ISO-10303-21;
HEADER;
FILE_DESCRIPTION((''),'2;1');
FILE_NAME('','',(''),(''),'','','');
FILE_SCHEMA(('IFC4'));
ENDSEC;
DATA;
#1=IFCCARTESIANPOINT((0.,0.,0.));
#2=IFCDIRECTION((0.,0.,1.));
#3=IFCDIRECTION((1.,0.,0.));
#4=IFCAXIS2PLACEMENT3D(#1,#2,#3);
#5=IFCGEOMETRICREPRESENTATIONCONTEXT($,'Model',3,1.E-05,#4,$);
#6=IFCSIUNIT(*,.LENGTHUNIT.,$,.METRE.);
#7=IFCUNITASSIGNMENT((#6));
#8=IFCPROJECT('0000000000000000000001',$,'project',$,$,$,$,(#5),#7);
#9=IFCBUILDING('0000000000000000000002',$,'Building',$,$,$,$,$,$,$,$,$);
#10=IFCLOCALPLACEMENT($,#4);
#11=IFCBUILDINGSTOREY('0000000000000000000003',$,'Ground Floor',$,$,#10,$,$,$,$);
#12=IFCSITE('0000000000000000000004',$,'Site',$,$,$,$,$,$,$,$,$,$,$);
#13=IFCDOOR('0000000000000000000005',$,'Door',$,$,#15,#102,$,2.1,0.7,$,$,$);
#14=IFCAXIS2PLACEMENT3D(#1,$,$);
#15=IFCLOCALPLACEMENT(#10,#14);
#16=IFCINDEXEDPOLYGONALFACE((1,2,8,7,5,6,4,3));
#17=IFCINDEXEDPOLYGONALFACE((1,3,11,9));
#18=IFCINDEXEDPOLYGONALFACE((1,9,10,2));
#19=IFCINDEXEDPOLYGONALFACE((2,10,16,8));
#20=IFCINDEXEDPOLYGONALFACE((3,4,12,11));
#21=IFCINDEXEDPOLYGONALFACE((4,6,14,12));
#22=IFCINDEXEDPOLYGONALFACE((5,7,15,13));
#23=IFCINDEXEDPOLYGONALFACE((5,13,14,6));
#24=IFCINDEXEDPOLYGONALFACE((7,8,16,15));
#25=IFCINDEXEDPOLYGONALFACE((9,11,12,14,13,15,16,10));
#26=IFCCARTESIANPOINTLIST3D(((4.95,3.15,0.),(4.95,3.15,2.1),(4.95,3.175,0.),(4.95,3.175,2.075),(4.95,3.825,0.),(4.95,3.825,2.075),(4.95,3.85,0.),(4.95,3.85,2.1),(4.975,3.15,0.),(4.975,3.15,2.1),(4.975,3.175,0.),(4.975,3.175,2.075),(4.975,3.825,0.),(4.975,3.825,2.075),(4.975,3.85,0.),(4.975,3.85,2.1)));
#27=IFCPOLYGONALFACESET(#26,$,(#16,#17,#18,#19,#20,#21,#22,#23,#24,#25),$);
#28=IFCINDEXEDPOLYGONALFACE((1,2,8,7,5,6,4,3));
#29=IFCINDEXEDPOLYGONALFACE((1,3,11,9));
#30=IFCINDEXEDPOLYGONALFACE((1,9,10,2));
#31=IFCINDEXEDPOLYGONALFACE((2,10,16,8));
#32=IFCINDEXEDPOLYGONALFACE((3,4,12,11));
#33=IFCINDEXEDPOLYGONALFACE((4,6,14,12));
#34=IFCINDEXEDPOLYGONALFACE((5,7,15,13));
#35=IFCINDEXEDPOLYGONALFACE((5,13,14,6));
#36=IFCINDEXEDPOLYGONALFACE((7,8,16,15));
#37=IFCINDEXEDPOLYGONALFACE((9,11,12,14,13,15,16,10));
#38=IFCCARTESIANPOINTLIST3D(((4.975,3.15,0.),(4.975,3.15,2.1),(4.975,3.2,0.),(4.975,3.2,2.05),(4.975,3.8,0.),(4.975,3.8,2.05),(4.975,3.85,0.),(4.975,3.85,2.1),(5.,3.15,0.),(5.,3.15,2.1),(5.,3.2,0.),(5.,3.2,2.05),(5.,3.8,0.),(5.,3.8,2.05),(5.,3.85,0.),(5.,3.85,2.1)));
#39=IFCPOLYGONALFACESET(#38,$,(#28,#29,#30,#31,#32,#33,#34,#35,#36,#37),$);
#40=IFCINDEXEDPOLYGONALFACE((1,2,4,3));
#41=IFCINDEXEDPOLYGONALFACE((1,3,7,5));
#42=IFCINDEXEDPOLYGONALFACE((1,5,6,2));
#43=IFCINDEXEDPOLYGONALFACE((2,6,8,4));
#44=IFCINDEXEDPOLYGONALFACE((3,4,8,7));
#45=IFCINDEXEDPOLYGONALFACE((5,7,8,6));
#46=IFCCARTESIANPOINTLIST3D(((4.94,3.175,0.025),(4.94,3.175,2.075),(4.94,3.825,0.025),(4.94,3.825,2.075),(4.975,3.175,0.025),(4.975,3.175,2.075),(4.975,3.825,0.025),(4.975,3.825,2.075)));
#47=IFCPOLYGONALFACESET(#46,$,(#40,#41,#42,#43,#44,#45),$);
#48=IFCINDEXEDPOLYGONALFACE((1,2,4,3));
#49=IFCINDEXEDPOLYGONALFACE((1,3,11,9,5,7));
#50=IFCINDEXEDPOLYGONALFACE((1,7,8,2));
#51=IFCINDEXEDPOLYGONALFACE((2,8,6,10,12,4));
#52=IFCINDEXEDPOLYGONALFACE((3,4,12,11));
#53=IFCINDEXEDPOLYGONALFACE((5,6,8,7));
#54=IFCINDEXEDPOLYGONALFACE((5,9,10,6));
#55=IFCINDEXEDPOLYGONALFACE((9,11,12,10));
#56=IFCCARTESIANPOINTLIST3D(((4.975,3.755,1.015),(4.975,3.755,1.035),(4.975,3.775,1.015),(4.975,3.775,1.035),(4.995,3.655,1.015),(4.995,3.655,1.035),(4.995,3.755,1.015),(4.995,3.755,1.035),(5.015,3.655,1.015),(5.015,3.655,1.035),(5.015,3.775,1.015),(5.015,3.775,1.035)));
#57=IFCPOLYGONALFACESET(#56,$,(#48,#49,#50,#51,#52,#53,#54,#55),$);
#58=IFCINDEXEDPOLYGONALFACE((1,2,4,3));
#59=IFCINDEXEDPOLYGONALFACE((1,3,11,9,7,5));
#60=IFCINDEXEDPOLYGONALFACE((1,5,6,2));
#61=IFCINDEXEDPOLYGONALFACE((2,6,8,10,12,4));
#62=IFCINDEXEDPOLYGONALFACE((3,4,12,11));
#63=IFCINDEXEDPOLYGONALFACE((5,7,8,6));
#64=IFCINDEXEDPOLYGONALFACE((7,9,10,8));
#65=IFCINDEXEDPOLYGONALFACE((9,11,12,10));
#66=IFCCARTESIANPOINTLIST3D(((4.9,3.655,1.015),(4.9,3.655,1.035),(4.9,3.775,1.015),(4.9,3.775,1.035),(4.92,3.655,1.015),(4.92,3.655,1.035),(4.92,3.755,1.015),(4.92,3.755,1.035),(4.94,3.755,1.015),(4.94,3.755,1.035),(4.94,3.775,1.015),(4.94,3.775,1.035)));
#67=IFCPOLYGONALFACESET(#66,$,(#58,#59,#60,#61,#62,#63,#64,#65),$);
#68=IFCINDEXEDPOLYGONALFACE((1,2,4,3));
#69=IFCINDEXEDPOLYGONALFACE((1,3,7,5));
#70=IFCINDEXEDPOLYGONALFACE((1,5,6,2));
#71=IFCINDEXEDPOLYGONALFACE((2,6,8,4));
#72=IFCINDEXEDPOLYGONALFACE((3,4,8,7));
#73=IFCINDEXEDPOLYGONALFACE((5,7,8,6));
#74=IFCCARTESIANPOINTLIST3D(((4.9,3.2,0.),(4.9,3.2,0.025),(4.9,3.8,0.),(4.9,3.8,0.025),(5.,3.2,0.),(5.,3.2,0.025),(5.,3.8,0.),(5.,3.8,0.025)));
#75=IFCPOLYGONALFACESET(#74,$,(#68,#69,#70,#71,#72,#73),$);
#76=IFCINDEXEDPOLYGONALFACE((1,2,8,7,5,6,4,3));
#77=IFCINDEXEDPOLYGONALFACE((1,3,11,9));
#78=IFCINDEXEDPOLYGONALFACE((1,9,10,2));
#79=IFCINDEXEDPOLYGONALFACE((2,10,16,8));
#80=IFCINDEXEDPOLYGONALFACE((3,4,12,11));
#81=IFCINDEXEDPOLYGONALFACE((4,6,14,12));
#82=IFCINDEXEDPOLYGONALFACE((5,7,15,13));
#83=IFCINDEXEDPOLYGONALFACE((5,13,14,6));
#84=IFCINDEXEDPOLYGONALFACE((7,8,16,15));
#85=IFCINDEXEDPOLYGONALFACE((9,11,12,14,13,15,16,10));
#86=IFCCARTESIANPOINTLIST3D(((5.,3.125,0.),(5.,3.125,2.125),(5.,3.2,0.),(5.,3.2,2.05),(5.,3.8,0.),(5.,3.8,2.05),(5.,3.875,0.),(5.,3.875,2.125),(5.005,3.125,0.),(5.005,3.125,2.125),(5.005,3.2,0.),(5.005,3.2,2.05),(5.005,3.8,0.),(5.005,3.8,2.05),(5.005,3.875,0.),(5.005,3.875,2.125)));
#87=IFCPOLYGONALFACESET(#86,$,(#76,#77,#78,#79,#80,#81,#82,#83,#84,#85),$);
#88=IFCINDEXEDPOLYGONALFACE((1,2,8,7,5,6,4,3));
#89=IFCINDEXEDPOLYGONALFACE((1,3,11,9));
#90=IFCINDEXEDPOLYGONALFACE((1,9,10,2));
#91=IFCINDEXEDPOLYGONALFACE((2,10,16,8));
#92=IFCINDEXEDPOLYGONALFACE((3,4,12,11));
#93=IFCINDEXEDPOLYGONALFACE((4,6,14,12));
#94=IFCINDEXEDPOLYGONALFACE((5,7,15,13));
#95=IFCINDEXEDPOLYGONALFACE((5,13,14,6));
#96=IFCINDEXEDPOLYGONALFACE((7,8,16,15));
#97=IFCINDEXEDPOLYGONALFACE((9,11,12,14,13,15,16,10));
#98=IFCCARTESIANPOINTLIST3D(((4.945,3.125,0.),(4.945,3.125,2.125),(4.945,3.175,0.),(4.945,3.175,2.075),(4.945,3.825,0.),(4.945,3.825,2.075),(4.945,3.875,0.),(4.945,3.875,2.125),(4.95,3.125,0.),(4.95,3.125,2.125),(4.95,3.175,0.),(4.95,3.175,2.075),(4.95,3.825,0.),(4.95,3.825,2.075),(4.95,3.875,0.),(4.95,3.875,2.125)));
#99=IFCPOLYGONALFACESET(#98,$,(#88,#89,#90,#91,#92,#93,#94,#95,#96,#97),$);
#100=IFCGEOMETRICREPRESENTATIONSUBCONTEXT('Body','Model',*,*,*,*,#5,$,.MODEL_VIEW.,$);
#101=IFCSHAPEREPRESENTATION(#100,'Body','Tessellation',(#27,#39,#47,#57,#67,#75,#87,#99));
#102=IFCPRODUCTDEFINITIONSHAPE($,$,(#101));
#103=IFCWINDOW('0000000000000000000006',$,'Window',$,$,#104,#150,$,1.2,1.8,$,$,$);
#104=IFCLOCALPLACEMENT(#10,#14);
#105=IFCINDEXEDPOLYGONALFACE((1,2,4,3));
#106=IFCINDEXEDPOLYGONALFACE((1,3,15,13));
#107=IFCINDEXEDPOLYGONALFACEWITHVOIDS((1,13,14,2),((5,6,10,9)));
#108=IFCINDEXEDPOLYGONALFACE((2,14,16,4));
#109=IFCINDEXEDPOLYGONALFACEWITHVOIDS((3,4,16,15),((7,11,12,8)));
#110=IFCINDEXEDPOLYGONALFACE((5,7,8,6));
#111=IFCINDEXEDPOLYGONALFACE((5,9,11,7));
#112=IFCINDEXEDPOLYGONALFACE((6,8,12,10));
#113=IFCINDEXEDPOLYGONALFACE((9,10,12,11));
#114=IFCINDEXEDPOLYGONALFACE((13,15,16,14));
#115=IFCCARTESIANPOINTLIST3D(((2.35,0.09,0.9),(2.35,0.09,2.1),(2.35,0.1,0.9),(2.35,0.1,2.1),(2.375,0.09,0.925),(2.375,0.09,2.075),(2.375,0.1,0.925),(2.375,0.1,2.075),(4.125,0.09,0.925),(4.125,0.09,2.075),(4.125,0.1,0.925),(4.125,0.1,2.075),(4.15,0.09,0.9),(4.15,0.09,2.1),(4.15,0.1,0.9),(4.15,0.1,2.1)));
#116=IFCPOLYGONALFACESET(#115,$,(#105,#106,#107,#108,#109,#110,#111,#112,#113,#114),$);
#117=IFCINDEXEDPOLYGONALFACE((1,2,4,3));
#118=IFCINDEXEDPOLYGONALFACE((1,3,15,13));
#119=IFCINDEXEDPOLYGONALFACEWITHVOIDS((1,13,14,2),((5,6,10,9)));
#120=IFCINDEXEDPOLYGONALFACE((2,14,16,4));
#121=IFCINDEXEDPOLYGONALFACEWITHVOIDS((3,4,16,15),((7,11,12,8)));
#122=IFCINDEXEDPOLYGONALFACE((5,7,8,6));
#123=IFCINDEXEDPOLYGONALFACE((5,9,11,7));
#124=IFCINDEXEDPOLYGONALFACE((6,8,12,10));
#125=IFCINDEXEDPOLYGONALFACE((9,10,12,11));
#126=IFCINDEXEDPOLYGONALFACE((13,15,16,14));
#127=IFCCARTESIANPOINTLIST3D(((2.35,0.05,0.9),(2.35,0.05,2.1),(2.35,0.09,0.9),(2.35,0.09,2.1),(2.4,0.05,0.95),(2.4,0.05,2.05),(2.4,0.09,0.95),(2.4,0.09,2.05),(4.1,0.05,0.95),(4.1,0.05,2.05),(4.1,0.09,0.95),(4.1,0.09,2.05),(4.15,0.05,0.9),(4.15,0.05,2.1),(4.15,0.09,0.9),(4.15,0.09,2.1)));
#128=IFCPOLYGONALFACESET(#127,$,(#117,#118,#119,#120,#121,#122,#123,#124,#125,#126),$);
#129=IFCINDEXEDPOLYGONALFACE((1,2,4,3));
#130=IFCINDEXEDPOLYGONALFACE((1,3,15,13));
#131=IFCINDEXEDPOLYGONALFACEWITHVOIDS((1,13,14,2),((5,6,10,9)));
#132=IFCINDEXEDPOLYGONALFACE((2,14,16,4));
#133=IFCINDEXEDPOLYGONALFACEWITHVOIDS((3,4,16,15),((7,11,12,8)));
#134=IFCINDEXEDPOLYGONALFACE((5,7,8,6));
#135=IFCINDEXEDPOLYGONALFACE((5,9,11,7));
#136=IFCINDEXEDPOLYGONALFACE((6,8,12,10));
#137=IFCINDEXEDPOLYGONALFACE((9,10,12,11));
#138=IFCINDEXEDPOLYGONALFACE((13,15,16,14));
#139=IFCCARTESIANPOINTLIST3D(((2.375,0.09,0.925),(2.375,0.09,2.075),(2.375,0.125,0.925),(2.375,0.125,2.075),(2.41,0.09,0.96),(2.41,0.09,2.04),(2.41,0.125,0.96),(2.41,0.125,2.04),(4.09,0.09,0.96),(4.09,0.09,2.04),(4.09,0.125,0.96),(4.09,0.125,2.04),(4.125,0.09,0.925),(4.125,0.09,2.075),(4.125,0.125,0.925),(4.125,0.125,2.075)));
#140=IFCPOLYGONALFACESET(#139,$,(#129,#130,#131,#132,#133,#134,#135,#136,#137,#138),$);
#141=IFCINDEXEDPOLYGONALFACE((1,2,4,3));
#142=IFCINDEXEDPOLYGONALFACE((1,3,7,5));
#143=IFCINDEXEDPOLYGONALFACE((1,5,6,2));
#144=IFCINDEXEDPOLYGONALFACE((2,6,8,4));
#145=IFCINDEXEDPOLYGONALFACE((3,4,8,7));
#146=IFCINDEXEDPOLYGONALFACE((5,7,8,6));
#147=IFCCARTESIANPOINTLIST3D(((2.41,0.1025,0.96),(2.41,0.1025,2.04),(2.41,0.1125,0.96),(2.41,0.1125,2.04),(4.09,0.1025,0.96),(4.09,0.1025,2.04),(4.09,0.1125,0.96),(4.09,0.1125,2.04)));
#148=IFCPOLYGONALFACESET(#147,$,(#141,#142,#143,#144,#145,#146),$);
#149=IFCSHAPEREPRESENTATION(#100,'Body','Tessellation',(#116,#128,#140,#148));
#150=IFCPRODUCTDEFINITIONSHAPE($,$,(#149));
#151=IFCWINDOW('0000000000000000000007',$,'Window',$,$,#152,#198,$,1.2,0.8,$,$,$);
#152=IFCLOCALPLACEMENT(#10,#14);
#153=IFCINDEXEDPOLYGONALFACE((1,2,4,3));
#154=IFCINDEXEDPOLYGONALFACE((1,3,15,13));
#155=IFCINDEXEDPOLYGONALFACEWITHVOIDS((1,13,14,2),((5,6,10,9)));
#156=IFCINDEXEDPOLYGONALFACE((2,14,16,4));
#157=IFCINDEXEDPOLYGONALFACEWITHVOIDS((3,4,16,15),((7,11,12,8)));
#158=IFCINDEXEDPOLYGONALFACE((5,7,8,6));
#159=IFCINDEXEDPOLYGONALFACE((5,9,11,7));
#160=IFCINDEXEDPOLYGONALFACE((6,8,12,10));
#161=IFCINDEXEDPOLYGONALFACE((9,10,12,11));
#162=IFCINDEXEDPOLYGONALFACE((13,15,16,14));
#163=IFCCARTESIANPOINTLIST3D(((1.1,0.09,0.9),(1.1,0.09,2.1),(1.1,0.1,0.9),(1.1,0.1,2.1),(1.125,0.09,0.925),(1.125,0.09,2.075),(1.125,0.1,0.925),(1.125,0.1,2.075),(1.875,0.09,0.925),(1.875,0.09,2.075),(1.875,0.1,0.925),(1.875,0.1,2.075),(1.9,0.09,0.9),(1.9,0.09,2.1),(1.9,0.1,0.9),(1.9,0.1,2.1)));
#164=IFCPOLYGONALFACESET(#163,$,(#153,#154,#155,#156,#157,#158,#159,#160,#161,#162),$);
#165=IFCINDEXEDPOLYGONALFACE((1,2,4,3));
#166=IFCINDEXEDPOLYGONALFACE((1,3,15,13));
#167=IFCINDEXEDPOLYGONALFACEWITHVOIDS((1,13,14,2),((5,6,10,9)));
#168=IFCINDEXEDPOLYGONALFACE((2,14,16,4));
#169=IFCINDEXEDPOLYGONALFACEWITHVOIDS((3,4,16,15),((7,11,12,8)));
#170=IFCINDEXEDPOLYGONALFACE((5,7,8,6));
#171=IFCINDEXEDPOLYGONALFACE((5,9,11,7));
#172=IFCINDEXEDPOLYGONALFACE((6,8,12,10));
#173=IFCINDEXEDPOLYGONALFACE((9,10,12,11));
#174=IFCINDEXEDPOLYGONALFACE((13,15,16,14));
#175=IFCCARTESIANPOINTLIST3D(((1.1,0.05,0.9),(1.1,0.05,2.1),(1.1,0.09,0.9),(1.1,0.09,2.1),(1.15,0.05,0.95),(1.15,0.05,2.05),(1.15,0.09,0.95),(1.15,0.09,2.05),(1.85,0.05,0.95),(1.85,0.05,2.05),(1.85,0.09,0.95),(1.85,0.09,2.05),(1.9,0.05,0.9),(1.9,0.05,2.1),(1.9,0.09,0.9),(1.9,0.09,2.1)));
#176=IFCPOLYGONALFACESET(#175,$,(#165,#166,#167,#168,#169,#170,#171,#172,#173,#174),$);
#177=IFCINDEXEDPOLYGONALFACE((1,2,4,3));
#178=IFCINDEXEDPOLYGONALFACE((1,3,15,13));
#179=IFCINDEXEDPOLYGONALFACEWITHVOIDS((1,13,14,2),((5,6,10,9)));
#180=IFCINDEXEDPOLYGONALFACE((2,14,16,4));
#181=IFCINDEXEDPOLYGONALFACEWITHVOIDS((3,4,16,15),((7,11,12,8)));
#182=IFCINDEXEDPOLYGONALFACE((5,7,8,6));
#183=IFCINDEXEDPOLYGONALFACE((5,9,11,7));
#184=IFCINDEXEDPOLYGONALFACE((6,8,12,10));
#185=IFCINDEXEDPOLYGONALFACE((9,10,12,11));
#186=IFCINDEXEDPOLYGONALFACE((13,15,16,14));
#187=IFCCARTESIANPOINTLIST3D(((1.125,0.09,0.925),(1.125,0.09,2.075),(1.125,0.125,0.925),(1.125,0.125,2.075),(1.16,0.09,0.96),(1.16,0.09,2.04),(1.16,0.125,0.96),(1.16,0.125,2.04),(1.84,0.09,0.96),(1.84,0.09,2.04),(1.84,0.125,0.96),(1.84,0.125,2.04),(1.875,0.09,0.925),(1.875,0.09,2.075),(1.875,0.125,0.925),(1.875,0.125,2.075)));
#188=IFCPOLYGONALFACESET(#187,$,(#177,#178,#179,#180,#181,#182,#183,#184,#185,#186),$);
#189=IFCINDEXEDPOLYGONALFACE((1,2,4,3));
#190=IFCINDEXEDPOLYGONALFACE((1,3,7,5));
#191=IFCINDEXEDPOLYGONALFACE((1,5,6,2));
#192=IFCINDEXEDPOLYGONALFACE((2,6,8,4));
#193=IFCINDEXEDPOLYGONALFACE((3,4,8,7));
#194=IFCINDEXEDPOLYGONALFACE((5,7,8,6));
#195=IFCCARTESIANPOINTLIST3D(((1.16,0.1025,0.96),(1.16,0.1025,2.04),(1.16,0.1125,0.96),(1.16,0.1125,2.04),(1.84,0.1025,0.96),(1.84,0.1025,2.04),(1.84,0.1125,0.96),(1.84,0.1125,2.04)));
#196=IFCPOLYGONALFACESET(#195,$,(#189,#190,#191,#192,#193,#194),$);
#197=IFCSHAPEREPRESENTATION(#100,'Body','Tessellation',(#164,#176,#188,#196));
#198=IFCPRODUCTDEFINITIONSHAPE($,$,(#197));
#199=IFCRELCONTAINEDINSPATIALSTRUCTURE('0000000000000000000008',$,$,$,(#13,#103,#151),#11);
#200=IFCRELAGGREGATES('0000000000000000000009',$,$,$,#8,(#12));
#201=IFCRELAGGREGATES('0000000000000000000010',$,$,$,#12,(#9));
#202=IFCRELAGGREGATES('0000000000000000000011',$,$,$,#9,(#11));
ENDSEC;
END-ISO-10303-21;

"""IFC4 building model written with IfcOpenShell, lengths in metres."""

from ifc_helpers import new_model, si_unit, frame, origin_with_axes, place, context, subcontext, project, spatial, line, indexed_curve, outline, extrude, element, save


model = new_model("IFC4")

# Units and contexts
model_context = context("Model", 3, precision=1e-05, world=origin_with_axes())
body_context = subcontext(model_context, "Body", "Model", "MODEL_VIEW")
ifc_project = project(units=[si_unit("LENGTHUNIT", "METRE")], contexts=[model_context])

# Site, building, storey
site = spatial("IfcSite", under=ifc_project, Name="Site")
building = spatial("IfcBuilding", under=site, Name="Building")
storey_placement = place(None, origin_with_axes())
storey = spatial("IfcBuildingStorey", under=building, at=storey_placement, Name="Ground Floor")

# Door
door_1_placement = place(storey_placement, frame((5.0, 3.15, 0.0), z_axis=(0.0, 0.0, 1.0), x_axis=(0.0, 1.0, 0.0)))
element("IfcDoor", 1, at=door_1_placement, inside=storey, Name="Door", OverallHeight=2.1, OverallWidth=0.7, context=body_context, shape_type="SweptSolid", body=[
    extrude(outline(indexed_curve([(0.0, 0.0), (0.0, 2.1), (0.7, 2.1), (0.7, 0.0), (0.675, 0.0), (0.675, 2.075), (0.025, 2.075), (0.025, 0.0)], segments=[line(1, 2, 3, 4, 5, 6, 7, 8, 1)])), frame((0.0, 0.025, 0.0), z_axis=(0.0, -1.0, 0.0), x_axis=(1.0, 0.0, 0.0)), (0.0, 0.0, -1.0), 0.025),
    extrude(outline(indexed_curve([(0.0, 0.0), (0.0, 2.1), (0.7, 2.1), (0.7, 0.0), (0.65, 0.0), (0.65, 2.05), (0.05, 2.05), (0.05, 0.0)], segments=[line(1, 2, 3, 4, 5, 6, 7, 8, 1)])), frame((0.0, 0.0, 0.0), z_axis=(0.0, -1.0, 0.0), x_axis=(1.0, 0.0, 0.0)), (0.0, 0.0, -1.0), 0.025),
    extrude(outline(indexed_curve([(0.0, 0.0), (0.65, 0.0), (0.65, 0.035), (0.0, 0.035)], segments=[line(1, 2, 3, 4, 1)])), frame((0.025, 0.025, 0.025), z_axis=(0.0, 0.0, 1.0), x_axis=(1.0, 0.0, 0.0)), (0.0, 0.0, 1.0), 2.05),
    extrude(outline(indexed_curve([(0.0, 0.0), (0.0, -0.04), (-0.12, -0.04), (-0.12, -0.02), (-0.02, -0.02), (-0.02, 0.0)], segments=[line(1, 2, 3, 4, 5, 6, 1)])), frame((0.625, 0.025, 1.015), z_axis=(0.0, 0.0, 1.0), x_axis=(1.0, 0.0, 0.0)), (0.0, 0.0, 1.0), 0.02),
    extrude(outline(indexed_curve([(0.0, 0.0), (0.0, 0.04), (-0.12, 0.04), (-0.12, 0.02), (-0.02, 0.02), (-0.02, 0.0)], segments=[line(1, 2, 3, 4, 5, 6, 1)])), frame((0.625, 0.06, 1.015), z_axis=(0.0, 0.0, 1.0), x_axis=(1.0, 0.0, 0.0)), (0.0, 0.0, 1.0), 0.02),
    extrude(outline(indexed_curve([(0.0, 0.0), (0.6, 0.0), (0.6, 0.1), (0.0, 0.1)], segments=[line(1, 2, 3, 4, 1)])), frame((0.05, 0.0, 0.0), z_axis=(0.0, 0.0, 1.0), x_axis=(1.0, 0.0, 0.0)), (0.0, 0.0, 1.0), 0.025),
    extrude(outline(indexed_curve([(0.0, 0.0), (0.0, 2.125), (0.75, 2.125), (0.75, 0.0), (0.675, 0.0), (0.675, 2.05), (0.075, 2.05), (0.075, 0.0)], segments=[line(1, 2, 3, 4, 5, 6, 7, 8, 1)])), frame((-0.025, -0.005, 0.0), z_axis=(0.0, -1.0, 0.0), x_axis=(1.0, 0.0, 0.0)), (0.0, 0.0, -1.0), 0.005),
    extrude(outline(indexed_curve([(0.0, 0.0), (0.0, 2.125), (0.75, 2.125), (0.75, 0.0), (0.7, 0.0), (0.7, 2.075), (0.05, 2.075), (0.05, 0.0)], segments=[line(1, 2, 3, 4, 5, 6, 7, 8, 1)])), frame((-0.025, 0.05, 0.0), z_axis=(0.0, -1.0, 0.0), x_axis=(1.0, 0.0, 0.0)), (0.0, 0.0, -1.0), 0.005),
])

# Windows
window_1_placement = place(storey_placement, frame((2.35, 0.0, 0.9), z_axis=(0.0, 0.0, 1.0), x_axis=(1.0, 0.0, 0.0)))
element("IfcWindow", 2, at=window_1_placement, inside=storey, Name="Window", OverallHeight=1.2, OverallWidth=1.8, context=body_context, shape_type="SweptSolid", body=[
    extrude(outline(indexed_curve([(0.0, 0.0), (1.8, 0.0), (1.8, 1.2), (0.0, 1.2)], segments=[line(1, 2, 3, 4, 1)]), holes=[indexed_curve([(0.025, 0.025), (1.775, 0.025), (1.775, 1.175), (0.025, 1.175)], segments=[line(1, 2, 3, 4, 1)])]), frame((0.0, 0.09, 0.0), z_axis=(0.0, -1.0, 0.0), x_axis=(1.0, 0.0, 0.0)), (0.0, 0.0, -1.0), 0.01),
    extrude(outline(indexed_curve([(0.0, 0.0), (1.8, 0.0), (1.8, 1.2), (0.0, 1.2)], segments=[line(1, 2, 3, 4, 1)]), holes=[indexed_curve([(0.05, 0.05), (1.75, 0.05), (1.75, 1.15), (0.05, 1.15)], segments=[line(1, 2, 3, 4, 1)])]), frame((0.0, 0.05, 0.0), z_axis=(0.0, -1.0, 0.0), x_axis=(1.0, 0.0, 0.0)), (0.0, 0.0, -1.0), 0.04),
    extrude(outline(indexed_curve([(0.0, 0.0), (1.75, 0.0), (1.75, 1.15), (0.0, 1.15)], segments=[line(1, 2, 3, 4, 1)]), holes=[indexed_curve([(0.035, 0.035), (1.715, 0.035), (1.715, 1.115), (0.035, 1.115)], segments=[line(1, 2, 3, 4, 1)])]), frame((0.025, 0.09, 0.025), z_axis=(0.0, -1.0, 0.0), x_axis=(1.0, 0.0, 0.0)), (0.0, 0.0, -1.0), 0.035),
    extrude(outline(indexed_curve([(0.035, 0.035), (1.715, 0.035), (1.715, 1.115), (0.035, 1.115)], segments=[line(1, 2, 3, 4, 1)])), frame((0.025, 0.1025, 0.025), z_axis=(0.0, -1.0, 0.0), x_axis=(1.0, 0.0, 0.0)), (0.0, 0.0, -1.0), 0.01),
])
window_2_placement = place(storey_placement, frame((1.1, 0.0, 0.9), z_axis=(0.0, 0.0, 1.0), x_axis=(1.0, 0.0, 0.0)))
element("IfcWindow", 3, at=window_2_placement, inside=storey, Name="Window", OverallHeight=1.2, OverallWidth=0.8, context=body_context, shape_type="SweptSolid", body=[
    extrude(outline(indexed_curve([(0.0, 0.0), (0.8, 0.0), (0.8, 1.2), (0.0, 1.2)], segments=[line(1, 2, 3, 4, 1)]), holes=[indexed_curve([(0.025, 0.025), (0.775, 0.025), (0.775, 1.175), (0.025, 1.175)], segments=[line(1, 2, 3, 4, 1)])]), frame((0.0, 0.09, 0.0), z_axis=(0.0, -1.0, 0.0), x_axis=(1.0, 0.0, 0.0)), (0.0, 0.0, -1.0), 0.01),
    extrude(outline(indexed_curve([(0.0, 0.0), (0.8, 0.0), (0.8, 1.2), (0.0, 1.2)], segments=[line(1, 2, 3, 4, 1)]), holes=[indexed_curve([(0.05, 0.05), (0.75, 0.05), (0.75, 1.15), (0.05, 1.15)], segments=[line(1, 2, 3, 4, 1)])]), frame((0.0, 0.05, 0.0), z_axis=(0.0, -1.0, 0.0), x_axis=(1.0, 0.0, 0.0)), (0.0, 0.0, -1.0), 0.04),
    extrude(outline(indexed_curve([(0.0, 0.0), (0.75, 0.0), (0.75, 1.15), (0.0, 1.15)], segments=[line(1, 2, 3, 4, 1)]), holes=[indexed_curve([(0.035, 0.035), (0.715, 0.035), (0.715, 1.115), (0.035, 1.115)], segments=[line(1, 2, 3, 4, 1)])]), frame((0.025, 0.09, 0.025), z_axis=(0.0, -1.0, 0.0), x_axis=(1.0, 0.0, 0.0)), (0.0, 0.0, -1.0), 0.035),
    extrude(outline(indexed_curve([(0.035, 0.035), (0.715, 0.035), (0.715, 1.115), (0.035, 1.115)], segments=[line(1, 2, 3, 4, 1)])), frame((0.025, 0.1025, 0.025), z_axis=(0.0, -1.0, 0.0), x_axis=(1.0, 0.0, 0.0)), (0.0, 0.0, -1.0), 0.01),
])

save(model, "model.ifc")
